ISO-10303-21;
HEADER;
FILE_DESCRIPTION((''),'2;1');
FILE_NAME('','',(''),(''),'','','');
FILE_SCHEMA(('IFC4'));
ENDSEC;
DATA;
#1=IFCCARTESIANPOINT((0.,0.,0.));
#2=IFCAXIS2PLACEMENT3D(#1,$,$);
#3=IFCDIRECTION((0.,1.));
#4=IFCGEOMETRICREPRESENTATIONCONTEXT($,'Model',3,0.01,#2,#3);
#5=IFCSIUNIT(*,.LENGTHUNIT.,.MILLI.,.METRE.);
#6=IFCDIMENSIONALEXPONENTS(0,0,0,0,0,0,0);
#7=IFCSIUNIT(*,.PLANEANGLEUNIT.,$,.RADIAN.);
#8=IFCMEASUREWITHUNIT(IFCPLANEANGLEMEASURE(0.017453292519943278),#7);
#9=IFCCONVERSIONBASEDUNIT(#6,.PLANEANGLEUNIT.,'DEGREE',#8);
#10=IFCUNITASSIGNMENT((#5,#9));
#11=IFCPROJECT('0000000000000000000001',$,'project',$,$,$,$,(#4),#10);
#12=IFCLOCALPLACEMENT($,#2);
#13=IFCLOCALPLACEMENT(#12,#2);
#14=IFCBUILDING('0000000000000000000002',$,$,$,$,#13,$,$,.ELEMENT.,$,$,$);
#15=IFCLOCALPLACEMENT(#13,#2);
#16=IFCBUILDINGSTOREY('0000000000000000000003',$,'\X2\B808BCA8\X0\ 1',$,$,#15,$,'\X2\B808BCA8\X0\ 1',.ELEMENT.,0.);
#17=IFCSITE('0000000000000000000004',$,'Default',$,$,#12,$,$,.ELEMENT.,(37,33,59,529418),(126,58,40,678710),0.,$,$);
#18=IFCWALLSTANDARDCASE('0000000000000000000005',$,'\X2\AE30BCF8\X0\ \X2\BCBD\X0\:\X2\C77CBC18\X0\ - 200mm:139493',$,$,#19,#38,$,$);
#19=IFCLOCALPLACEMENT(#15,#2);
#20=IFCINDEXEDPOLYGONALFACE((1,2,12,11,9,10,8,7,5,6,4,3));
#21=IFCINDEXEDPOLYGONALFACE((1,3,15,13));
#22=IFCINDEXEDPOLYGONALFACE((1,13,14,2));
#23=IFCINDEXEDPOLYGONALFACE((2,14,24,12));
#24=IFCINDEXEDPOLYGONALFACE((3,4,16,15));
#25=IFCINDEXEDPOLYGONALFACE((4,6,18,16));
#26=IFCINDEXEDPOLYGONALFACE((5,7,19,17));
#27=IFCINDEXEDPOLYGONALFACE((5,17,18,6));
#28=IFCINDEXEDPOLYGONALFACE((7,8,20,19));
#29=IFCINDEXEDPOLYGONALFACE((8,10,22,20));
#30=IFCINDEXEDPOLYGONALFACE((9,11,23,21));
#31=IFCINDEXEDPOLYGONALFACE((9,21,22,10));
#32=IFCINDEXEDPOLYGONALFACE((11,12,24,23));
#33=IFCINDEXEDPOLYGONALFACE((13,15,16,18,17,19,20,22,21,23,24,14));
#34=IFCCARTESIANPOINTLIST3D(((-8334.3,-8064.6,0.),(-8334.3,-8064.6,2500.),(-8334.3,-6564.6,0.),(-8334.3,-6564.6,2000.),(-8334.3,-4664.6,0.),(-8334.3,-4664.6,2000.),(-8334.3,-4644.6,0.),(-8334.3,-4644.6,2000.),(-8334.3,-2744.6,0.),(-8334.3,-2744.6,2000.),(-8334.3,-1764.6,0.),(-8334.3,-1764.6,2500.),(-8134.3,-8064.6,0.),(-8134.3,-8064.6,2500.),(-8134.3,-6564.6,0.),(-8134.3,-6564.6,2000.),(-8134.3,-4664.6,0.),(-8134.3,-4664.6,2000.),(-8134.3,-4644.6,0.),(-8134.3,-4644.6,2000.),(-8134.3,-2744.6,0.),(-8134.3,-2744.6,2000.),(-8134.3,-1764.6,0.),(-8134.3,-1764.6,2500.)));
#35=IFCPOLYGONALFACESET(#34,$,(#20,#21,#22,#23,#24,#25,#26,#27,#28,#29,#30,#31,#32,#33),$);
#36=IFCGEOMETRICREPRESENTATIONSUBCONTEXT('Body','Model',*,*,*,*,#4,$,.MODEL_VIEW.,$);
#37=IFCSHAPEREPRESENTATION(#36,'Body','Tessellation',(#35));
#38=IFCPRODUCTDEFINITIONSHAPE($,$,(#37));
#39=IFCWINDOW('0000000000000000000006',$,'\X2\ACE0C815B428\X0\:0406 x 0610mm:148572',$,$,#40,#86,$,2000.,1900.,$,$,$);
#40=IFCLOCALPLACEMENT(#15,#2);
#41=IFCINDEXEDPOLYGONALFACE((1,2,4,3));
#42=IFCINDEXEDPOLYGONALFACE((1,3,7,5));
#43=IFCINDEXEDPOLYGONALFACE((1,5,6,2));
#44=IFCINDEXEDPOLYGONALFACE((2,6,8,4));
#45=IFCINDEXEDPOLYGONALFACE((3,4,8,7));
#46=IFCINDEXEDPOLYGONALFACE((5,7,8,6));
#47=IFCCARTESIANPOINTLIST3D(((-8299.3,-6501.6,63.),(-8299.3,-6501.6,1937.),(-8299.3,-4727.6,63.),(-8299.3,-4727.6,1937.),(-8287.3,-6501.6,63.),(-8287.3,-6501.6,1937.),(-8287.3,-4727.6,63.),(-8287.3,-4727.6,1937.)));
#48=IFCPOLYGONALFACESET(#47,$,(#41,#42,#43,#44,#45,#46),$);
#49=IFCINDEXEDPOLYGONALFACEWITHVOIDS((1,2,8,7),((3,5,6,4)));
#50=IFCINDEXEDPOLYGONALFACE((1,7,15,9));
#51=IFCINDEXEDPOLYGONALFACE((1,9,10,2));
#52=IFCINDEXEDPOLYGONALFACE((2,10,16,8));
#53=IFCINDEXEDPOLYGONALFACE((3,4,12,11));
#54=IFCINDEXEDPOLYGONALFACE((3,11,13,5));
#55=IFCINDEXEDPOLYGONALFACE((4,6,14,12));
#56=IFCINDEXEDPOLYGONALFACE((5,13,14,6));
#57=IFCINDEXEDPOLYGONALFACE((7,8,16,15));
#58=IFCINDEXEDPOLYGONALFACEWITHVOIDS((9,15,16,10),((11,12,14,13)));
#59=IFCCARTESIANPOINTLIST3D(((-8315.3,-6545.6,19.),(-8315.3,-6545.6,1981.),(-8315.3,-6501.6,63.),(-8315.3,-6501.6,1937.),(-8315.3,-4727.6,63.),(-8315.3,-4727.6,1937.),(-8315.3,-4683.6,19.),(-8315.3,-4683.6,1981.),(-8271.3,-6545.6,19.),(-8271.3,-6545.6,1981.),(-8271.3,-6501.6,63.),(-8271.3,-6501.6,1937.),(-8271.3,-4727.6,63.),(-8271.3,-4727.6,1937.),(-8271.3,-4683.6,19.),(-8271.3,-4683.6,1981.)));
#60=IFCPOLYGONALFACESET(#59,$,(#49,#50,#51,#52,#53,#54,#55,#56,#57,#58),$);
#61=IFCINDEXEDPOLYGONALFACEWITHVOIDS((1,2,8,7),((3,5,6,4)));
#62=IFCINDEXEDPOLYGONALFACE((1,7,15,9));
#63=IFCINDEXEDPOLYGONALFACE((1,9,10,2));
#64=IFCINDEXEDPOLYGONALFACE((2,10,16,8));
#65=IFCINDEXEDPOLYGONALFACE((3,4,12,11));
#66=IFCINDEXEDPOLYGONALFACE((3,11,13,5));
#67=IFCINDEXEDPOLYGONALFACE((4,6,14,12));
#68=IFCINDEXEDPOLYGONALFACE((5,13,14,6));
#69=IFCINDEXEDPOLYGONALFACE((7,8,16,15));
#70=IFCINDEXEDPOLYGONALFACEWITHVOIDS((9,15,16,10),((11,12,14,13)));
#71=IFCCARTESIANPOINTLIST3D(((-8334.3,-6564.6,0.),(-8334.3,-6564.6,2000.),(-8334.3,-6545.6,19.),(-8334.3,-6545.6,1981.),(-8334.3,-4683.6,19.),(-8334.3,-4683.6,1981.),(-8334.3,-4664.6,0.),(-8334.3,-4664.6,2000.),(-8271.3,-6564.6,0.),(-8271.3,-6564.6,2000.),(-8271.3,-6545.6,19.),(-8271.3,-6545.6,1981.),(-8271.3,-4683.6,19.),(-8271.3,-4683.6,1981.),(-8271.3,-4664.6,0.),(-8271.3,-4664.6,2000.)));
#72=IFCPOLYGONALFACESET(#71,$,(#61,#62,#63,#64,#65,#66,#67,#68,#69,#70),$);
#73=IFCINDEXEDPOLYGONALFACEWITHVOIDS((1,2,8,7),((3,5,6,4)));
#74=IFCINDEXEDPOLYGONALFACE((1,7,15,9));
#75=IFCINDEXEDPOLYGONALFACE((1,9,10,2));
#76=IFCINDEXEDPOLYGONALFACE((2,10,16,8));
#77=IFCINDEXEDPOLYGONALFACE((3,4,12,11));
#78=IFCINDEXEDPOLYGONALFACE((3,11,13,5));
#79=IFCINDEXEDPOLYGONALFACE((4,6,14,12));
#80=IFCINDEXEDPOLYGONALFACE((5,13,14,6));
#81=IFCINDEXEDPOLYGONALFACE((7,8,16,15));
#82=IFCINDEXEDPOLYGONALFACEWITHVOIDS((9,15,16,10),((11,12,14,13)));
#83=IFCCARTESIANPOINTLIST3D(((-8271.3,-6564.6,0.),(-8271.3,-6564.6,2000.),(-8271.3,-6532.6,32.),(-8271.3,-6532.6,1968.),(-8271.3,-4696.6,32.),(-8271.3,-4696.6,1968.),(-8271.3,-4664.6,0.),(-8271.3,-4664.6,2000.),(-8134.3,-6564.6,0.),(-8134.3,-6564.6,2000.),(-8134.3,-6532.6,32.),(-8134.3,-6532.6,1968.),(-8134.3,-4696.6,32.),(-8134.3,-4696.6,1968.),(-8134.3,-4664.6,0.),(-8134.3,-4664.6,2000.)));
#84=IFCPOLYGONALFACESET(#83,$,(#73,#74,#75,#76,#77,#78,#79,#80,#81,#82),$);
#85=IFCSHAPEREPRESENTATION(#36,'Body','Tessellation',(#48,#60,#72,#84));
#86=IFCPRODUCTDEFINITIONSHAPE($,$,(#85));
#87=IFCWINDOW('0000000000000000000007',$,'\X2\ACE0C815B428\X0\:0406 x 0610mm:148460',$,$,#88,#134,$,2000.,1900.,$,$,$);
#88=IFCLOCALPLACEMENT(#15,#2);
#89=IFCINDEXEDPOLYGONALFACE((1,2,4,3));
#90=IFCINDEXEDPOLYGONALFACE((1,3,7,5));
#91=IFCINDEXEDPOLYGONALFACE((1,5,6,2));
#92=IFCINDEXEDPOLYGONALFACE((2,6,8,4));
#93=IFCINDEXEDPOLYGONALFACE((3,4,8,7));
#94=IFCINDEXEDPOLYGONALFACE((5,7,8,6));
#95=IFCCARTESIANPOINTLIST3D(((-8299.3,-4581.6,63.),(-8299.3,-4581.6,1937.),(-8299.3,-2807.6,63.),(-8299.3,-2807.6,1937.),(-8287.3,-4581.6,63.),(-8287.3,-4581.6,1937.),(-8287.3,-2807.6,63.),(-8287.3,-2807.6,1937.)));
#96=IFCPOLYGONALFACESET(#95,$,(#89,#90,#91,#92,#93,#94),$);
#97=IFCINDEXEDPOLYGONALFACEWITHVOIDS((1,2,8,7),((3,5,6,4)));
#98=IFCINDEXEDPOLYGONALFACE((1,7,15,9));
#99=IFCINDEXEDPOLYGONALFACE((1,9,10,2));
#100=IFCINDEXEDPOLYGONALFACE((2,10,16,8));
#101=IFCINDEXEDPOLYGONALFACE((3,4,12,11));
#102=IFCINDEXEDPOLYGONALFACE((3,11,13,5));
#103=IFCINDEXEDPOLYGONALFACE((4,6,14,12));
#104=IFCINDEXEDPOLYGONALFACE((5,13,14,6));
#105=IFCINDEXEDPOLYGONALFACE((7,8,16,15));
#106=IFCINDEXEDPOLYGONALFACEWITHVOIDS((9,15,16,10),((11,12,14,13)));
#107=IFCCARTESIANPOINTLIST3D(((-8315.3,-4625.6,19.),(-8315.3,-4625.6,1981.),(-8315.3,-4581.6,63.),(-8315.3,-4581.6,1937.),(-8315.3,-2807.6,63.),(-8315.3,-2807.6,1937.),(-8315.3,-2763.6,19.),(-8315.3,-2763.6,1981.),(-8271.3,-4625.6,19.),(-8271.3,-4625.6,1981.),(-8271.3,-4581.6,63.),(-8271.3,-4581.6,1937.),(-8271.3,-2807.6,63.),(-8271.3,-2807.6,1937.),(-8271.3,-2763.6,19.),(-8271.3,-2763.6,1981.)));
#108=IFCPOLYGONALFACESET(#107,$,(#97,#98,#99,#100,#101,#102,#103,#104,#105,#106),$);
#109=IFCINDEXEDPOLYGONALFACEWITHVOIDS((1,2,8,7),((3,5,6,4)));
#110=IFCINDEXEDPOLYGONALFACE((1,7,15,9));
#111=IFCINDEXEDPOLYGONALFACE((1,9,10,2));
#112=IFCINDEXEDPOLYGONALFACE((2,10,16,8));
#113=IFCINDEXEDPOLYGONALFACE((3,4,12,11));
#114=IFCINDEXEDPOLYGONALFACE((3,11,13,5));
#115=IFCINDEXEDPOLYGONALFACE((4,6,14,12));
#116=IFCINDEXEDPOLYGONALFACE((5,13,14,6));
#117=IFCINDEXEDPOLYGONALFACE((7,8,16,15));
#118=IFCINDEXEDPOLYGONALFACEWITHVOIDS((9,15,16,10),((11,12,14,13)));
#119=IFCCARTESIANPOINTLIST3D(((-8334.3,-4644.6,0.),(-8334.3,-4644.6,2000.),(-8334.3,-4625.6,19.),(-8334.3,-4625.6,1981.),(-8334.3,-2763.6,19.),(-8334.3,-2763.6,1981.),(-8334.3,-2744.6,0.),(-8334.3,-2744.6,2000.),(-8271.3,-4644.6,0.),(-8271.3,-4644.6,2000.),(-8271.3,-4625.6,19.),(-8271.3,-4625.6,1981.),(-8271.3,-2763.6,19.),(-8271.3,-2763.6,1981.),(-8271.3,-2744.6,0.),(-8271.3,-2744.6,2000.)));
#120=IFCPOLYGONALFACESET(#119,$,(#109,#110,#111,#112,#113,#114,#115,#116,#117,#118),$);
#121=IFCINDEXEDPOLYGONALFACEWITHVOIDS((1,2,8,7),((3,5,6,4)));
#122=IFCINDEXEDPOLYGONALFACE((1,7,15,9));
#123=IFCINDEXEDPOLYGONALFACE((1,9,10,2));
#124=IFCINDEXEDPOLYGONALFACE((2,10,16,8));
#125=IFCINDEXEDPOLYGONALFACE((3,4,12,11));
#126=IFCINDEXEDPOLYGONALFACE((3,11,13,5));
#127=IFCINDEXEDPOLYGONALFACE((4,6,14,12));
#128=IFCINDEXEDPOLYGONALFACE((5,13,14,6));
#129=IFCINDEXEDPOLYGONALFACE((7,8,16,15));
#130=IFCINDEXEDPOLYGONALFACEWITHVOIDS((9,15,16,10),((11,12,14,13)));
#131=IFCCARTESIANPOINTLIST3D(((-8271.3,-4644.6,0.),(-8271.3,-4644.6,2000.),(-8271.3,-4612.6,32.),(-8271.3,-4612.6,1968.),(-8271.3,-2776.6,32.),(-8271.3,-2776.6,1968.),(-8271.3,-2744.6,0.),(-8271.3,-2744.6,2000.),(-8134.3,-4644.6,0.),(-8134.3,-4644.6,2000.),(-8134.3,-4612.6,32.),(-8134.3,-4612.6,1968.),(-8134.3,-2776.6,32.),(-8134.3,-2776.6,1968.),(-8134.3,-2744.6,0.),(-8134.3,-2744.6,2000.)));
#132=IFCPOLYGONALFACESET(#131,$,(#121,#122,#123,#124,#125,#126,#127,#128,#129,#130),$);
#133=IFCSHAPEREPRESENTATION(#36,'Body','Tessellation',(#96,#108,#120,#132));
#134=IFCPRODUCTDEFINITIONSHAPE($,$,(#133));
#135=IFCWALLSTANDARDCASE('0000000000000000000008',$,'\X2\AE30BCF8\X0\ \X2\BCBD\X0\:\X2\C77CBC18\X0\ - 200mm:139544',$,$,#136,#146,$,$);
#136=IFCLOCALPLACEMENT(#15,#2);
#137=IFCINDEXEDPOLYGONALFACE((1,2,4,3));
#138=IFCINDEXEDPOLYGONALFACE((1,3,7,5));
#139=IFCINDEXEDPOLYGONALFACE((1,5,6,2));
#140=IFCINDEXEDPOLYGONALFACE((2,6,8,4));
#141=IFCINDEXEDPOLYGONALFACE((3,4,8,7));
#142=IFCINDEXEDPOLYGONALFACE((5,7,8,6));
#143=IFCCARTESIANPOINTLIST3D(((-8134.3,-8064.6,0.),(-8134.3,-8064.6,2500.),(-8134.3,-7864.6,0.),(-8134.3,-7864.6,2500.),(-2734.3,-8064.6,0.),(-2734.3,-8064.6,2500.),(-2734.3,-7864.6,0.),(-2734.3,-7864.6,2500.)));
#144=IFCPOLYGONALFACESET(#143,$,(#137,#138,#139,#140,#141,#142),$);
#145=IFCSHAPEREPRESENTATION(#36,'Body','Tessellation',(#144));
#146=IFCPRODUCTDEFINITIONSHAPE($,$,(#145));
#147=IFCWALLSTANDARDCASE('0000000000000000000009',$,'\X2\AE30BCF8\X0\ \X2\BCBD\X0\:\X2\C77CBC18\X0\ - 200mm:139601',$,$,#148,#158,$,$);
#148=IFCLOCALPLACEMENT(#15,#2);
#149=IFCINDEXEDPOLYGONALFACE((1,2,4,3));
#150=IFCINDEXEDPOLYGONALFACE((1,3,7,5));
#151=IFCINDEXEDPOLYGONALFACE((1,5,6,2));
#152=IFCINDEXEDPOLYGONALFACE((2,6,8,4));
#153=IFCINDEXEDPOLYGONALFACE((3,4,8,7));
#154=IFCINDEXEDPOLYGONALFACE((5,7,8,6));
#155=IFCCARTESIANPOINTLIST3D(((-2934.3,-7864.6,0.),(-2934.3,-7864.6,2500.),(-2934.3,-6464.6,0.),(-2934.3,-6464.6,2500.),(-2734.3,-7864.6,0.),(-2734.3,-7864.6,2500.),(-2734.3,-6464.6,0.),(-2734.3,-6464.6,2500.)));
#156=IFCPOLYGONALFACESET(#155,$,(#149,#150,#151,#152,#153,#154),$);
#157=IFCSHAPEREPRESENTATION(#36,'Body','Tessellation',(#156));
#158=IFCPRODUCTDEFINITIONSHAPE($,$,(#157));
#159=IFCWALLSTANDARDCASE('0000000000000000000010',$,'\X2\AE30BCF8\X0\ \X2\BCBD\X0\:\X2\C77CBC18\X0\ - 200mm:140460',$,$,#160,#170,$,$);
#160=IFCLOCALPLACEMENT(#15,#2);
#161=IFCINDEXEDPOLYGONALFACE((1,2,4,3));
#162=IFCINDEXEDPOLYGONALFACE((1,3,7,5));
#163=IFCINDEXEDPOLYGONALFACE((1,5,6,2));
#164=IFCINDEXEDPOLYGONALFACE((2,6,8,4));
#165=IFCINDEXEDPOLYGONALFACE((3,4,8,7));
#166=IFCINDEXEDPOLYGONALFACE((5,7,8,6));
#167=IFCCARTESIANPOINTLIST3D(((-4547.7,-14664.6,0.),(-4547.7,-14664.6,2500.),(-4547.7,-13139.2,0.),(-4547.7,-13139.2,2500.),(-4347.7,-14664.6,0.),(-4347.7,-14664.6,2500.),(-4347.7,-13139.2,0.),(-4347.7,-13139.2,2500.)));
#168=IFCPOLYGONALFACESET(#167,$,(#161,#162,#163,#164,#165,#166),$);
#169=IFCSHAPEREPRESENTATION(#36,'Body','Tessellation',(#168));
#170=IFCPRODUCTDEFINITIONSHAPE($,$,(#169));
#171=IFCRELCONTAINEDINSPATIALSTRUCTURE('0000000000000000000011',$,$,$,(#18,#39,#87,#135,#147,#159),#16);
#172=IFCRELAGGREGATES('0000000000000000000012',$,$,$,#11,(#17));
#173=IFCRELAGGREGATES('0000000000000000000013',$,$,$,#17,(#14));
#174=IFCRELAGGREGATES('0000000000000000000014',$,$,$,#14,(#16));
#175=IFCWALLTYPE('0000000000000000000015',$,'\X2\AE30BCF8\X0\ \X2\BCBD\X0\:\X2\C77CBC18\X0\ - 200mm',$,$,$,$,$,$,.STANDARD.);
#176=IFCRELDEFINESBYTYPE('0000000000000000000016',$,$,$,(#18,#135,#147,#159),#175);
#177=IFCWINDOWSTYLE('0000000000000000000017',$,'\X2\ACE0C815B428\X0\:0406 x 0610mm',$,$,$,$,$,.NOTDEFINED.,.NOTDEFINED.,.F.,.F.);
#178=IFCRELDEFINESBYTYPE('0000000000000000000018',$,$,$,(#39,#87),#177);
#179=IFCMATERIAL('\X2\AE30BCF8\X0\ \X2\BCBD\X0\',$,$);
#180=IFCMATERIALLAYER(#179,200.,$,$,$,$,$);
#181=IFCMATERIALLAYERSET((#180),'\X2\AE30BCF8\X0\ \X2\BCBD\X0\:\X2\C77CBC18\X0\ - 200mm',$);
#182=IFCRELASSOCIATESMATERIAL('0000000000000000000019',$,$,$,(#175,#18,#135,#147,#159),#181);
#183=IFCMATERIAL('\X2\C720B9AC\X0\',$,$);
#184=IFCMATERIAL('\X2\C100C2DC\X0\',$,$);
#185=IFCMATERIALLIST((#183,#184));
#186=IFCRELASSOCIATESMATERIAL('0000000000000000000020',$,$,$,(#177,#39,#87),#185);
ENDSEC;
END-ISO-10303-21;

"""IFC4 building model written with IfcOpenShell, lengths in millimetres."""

from ifc_helpers import new_model, entity, si_unit, converted_unit, direction, frame, frame_2d, origin, place, context, subcontext, project, spatial, polyline, rectangle, outline, extrude, source, transform, mapped, material, material_list, layer, layer_set, layer_usage, type_object, type_shapes, element, fill, save


model = new_model("IFC4")

# Units and contexts
model_context = context("Model", 3, precision=0.01, world=origin(), true_north=direction((0.0, 1.0)))
body_context = subcontext(model_context, "Body", "Model", "MODEL_VIEW")
ifc_project = project(units=[si_unit("LENGTHUNIT", "METRE", prefix="MILLI"), converted_unit("PLANEANGLEUNIT", "DEGREE", entity("IfcPlaneAngleMeasure", 0.017453292519943278), si_unit("PLANEANGLEUNIT", "RADIAN"), dimensions=[0, 0, 0, 0, 0, 0, 0])], contexts=[model_context])

# Site, building, storey
site_placement = place(None, origin())
site = spatial("IfcSite", under=ifc_project, at=site_placement, Name="Default", CompositionType="ELEMENT", RefLatitude=(37, 33, 59, 529418), RefLongitude=(126, 58, 40, 678710), RefElevation=0.0)
building_placement = place(site_placement, origin())
building = spatial("IfcBuilding", under=site, at=building_placement, CompositionType="ELEMENT")
storey_placement = place(building_placement, origin())
storey = spatial("IfcBuildingStorey", under=building, at=storey_placement, Name="레벨 1", LongName="레벨 1", CompositionType="ELEMENT", Elevation=0.0)

# Shared definitions
ifc_material_1 = material(Name="기본 벽")
ifc_layer_1 = layer(ifc_material_1, 200.0)
ifc_layer_set_1 = layer_set([ifc_layer_1], Name="기본 벽:일반 - 200mm")
wall_type = type_object("IfcWallType", Name="기본 벽:일반 - 200mm", PredefinedType="STANDARD", material=ifc_layer_set_1)
ifc_material_2 = material(Name="유리")
ifc_material_3 = material(Name="섀시")
ifc_material_list = material_list([ifc_material_2, ifc_material_3])
window_style = type_object("IfcWindowStyle", Name="고정됨:0406 x 0610mm", ConstructionType="NOTDEFINED", OperationType="NOTDEFINED", ParameterTakesPrecedence=False, Sizeable=False, material=ifc_material_list)
shared_shape = source(origin(), body_context, "Body", "SweptSolid", [
    extrude(rectangle(XDim=12.0, YDim=1774.0, at=frame_2d((0.0, 0.0), x_axis=(1.0, 0.0))), frame((950.0, 159.0, 63.0), z_axis=(0.0, 0.0, 1.0), x_axis=(0.0, -1.0, 0.0)), (0.0, 0.0, 1.0), 1874.0),
    extrude(outline(polyline([(-931.0, -981.0), (931.0, -981.0), (931.0, 981.0), (-931.0, 981.0), (-931.0, -981.0)]), holes=[polyline([(-887.0, -937.0), (-887.0, 937.0), (887.0, 937.0), (887.0, -937.0), (-887.0, -937.0)])]), frame((950.0, 137.0, 1000.0), z_axis=(0.0, 1.0, 0.0), x_axis=(1.0, 0.0, 0.0)), (0.0, 0.0, 1.0), 44.0),
    extrude(outline(polyline([(-950.0, -1000.0), (950.0, -1000.0), (950.0, 1000.0), (-950.0, 1000.0), (-950.0, -1000.0)]), holes=[polyline([(-931.0, -981.0), (-931.0, 981.0), (931.0, 981.0), (931.0, -981.0), (-931.0, -981.0)])]), frame((950.0, 137.0, 1000.0), z_axis=(0.0, 1.0, 0.0), x_axis=(1.0, 0.0, 0.0)), (0.0, 0.0, 1.0), 63.0),
    extrude(outline(polyline([(-950.0, -1000.0), (950.0, -1000.0), (950.0, 1000.0), (-950.0, 1000.0), (-950.0, -1000.0)]), holes=[polyline([(-918.0, -968.0), (-918.0, 968.0), (918.0, 968.0), (918.0, -968.0), (-918.0, -968.0)])]), frame((950.0, 0.0, 1000.0), z_axis=(0.0, 1.0, 0.0), x_axis=(1.0, 0.0, 0.0)), (0.0, 0.0, 1.0), 137.0),
])
type_shapes(window_style, [shared_shape])

# Wall, openings, windows
ifc_layer_usage_1 = layer_usage(ifc_layer_set_1, "AXIS2", "NEGATIVE", 100.0)
wall_1_placement = place(storey_placement, frame((-8234.3, -1764.6, 0.0), z_axis=(0.0, 0.0, 1.0), x_axis=(0.0, -1.0, 0.0)))
wall_1 = element("IfcWallStandardCase", 1, at=wall_1_placement, inside=storey, type_object=wall_type, material=ifc_layer_usage_1, Name="기본 벽:일반 - 200mm:139493", context=body_context, shape_type="SweptSolid", body=[
    extrude(rectangle(XDim=6300.0, YDim=200.0, at=frame_2d((3150.0, 0.0), x_axis=(-1.0, 0.0))), origin(), (0.0, 0.0, 1.0), 2500.0),
])
opening_1_placement = place(wall_1_placement, frame((4800.0, 100.0, 0.0)))
opening_1 = element("IfcOpeningElement", 2, at=opening_1_placement, cuts=wall_1, ObjectType="Opening", context=body_context, shape_type="SweptSolid", body=[
    extrude(rectangle(XDim=2000.0, YDim=1900.0, at=frame_2d((1000.0, 950.0), x_axis=(1.0, 0.0))), frame((0.0, 0.0, 0.0), z_axis=(0.0, -1.0, 0.0), x_axis=(0.0, 0.0, 1.0)), (0.0, 0.0, 1.0), 200.0),
])
opening_2_placement = place(wall_1_placement, frame((2880.0, 100.0, 0.0)))
opening_2 = element("IfcOpeningElement", 3, at=opening_2_placement, cuts=wall_1, ObjectType="Opening", context=body_context, shape_type="SweptSolid", body=[
    extrude(rectangle(XDim=2000.0, YDim=1900.0, at=frame_2d((1000.0, 950.0), x_axis=(1.0, 0.0))), frame((0.0, 0.0, 0.0), z_axis=(0.0, -1.0, 0.0), x_axis=(0.0, 0.0, 1.0)), (0.0, 0.0, 1.0), 200.0),
])
window_1_placement = place(opening_1_placement, frame((0.0, 0.0, 0.0), z_axis=(0.0, 0.0, 1.0), x_axis=(-1.0, 0.0, 0.0)))
window_1 = element("IfcWindow", 4, at=window_1_placement, inside=storey, type_object=window_style, material=ifc_material_list, Name="고정됨:0406 x 0610mm:148572", OverallHeight=2000.0, OverallWidth=1900.0, context=body_context, shape_type="MappedRepresentation", body=[
    mapped(shared_shape, transform((0.0, 0.0, 0.0), scale=1.0)),
])
fill(opening_1, window_1)
window_2_placement = place(opening_2_placement, frame((0.0, 0.0, 0.0), z_axis=(0.0, 0.0, 1.0), x_axis=(-1.0, 0.0, 0.0)))
window_2 = element("IfcWindow", 5, at=window_2_placement, inside=storey, type_object=window_style, material=ifc_material_list, Name="고정됨:0406 x 0610mm:148460", OverallHeight=2000.0, OverallWidth=1900.0, context=body_context, shape_type="MappedRepresentation", body=[
    mapped(shared_shape, transform((0.0, 0.0, 0.0), scale=1.0)),
])
fill(opening_2, window_2)

# Walls
ifc_layer_usage_2 = layer_usage(ifc_layer_set_1, "AXIS2", "NEGATIVE", 100.0)
wall_2_placement = place(storey_placement, frame((-8134.3, -7964.6, 0.0)))
element("IfcWallStandardCase", 6, at=wall_2_placement, inside=storey, type_object=wall_type, material=ifc_layer_usage_2, Name="기본 벽:일반 - 200mm:139544", context=body_context, shape_type="SweptSolid", body=[
    extrude(rectangle(XDim=5400.0, YDim=200.0, at=frame_2d((2700.0, 0.0), x_axis=(-1.0, 0.0))), origin(), (0.0, 0.0, 1.0), 2500.0),
])
ifc_layer_usage_3 = layer_usage(ifc_layer_set_1, "AXIS2", "NEGATIVE", 100.0)
wall_3_placement = place(storey_placement, frame((-2834.3, -7864.6, 0.0), z_axis=(0.0, 0.0, 1.0), x_axis=(0.0, 1.0, 0.0)))
element("IfcWallStandardCase", 7, at=wall_3_placement, inside=storey, type_object=wall_type, material=ifc_layer_usage_3, Name="기본 벽:일반 - 200mm:139601", context=body_context, shape_type="SweptSolid", body=[
    extrude(rectangle(XDim=1400.0, YDim=200.0, at=frame_2d((700.0, 0.0), x_axis=(-1.0, 0.0))), origin(), (0.0, 0.0, 1.0), 2500.0),
])
ifc_layer_usage_4 = layer_usage(ifc_layer_set_1, "AXIS2", "NEGATIVE", 100.0)
wall_4_placement = place(storey_placement, frame((-4447.7, -13139.2, 0.0), z_axis=(0.0, 0.0, 1.0), x_axis=(0.0, -1.0, 0.0)))
element("IfcWallStandardCase", 8, at=wall_4_placement, inside=storey, type_object=wall_type, material=ifc_layer_usage_4, Name="기본 벽:일반 - 200mm:140460", context=body_context, shape_type="SweptSolid", body=[
    extrude(rectangle(XDim=1525.5, YDim=200.0, at=frame_2d((762.7, 0.0), x_axis=(-1.0, 0.0))), origin(), (0.0, 0.0, 1.0), 2500.0),
])

save(model, "model.ifc")
